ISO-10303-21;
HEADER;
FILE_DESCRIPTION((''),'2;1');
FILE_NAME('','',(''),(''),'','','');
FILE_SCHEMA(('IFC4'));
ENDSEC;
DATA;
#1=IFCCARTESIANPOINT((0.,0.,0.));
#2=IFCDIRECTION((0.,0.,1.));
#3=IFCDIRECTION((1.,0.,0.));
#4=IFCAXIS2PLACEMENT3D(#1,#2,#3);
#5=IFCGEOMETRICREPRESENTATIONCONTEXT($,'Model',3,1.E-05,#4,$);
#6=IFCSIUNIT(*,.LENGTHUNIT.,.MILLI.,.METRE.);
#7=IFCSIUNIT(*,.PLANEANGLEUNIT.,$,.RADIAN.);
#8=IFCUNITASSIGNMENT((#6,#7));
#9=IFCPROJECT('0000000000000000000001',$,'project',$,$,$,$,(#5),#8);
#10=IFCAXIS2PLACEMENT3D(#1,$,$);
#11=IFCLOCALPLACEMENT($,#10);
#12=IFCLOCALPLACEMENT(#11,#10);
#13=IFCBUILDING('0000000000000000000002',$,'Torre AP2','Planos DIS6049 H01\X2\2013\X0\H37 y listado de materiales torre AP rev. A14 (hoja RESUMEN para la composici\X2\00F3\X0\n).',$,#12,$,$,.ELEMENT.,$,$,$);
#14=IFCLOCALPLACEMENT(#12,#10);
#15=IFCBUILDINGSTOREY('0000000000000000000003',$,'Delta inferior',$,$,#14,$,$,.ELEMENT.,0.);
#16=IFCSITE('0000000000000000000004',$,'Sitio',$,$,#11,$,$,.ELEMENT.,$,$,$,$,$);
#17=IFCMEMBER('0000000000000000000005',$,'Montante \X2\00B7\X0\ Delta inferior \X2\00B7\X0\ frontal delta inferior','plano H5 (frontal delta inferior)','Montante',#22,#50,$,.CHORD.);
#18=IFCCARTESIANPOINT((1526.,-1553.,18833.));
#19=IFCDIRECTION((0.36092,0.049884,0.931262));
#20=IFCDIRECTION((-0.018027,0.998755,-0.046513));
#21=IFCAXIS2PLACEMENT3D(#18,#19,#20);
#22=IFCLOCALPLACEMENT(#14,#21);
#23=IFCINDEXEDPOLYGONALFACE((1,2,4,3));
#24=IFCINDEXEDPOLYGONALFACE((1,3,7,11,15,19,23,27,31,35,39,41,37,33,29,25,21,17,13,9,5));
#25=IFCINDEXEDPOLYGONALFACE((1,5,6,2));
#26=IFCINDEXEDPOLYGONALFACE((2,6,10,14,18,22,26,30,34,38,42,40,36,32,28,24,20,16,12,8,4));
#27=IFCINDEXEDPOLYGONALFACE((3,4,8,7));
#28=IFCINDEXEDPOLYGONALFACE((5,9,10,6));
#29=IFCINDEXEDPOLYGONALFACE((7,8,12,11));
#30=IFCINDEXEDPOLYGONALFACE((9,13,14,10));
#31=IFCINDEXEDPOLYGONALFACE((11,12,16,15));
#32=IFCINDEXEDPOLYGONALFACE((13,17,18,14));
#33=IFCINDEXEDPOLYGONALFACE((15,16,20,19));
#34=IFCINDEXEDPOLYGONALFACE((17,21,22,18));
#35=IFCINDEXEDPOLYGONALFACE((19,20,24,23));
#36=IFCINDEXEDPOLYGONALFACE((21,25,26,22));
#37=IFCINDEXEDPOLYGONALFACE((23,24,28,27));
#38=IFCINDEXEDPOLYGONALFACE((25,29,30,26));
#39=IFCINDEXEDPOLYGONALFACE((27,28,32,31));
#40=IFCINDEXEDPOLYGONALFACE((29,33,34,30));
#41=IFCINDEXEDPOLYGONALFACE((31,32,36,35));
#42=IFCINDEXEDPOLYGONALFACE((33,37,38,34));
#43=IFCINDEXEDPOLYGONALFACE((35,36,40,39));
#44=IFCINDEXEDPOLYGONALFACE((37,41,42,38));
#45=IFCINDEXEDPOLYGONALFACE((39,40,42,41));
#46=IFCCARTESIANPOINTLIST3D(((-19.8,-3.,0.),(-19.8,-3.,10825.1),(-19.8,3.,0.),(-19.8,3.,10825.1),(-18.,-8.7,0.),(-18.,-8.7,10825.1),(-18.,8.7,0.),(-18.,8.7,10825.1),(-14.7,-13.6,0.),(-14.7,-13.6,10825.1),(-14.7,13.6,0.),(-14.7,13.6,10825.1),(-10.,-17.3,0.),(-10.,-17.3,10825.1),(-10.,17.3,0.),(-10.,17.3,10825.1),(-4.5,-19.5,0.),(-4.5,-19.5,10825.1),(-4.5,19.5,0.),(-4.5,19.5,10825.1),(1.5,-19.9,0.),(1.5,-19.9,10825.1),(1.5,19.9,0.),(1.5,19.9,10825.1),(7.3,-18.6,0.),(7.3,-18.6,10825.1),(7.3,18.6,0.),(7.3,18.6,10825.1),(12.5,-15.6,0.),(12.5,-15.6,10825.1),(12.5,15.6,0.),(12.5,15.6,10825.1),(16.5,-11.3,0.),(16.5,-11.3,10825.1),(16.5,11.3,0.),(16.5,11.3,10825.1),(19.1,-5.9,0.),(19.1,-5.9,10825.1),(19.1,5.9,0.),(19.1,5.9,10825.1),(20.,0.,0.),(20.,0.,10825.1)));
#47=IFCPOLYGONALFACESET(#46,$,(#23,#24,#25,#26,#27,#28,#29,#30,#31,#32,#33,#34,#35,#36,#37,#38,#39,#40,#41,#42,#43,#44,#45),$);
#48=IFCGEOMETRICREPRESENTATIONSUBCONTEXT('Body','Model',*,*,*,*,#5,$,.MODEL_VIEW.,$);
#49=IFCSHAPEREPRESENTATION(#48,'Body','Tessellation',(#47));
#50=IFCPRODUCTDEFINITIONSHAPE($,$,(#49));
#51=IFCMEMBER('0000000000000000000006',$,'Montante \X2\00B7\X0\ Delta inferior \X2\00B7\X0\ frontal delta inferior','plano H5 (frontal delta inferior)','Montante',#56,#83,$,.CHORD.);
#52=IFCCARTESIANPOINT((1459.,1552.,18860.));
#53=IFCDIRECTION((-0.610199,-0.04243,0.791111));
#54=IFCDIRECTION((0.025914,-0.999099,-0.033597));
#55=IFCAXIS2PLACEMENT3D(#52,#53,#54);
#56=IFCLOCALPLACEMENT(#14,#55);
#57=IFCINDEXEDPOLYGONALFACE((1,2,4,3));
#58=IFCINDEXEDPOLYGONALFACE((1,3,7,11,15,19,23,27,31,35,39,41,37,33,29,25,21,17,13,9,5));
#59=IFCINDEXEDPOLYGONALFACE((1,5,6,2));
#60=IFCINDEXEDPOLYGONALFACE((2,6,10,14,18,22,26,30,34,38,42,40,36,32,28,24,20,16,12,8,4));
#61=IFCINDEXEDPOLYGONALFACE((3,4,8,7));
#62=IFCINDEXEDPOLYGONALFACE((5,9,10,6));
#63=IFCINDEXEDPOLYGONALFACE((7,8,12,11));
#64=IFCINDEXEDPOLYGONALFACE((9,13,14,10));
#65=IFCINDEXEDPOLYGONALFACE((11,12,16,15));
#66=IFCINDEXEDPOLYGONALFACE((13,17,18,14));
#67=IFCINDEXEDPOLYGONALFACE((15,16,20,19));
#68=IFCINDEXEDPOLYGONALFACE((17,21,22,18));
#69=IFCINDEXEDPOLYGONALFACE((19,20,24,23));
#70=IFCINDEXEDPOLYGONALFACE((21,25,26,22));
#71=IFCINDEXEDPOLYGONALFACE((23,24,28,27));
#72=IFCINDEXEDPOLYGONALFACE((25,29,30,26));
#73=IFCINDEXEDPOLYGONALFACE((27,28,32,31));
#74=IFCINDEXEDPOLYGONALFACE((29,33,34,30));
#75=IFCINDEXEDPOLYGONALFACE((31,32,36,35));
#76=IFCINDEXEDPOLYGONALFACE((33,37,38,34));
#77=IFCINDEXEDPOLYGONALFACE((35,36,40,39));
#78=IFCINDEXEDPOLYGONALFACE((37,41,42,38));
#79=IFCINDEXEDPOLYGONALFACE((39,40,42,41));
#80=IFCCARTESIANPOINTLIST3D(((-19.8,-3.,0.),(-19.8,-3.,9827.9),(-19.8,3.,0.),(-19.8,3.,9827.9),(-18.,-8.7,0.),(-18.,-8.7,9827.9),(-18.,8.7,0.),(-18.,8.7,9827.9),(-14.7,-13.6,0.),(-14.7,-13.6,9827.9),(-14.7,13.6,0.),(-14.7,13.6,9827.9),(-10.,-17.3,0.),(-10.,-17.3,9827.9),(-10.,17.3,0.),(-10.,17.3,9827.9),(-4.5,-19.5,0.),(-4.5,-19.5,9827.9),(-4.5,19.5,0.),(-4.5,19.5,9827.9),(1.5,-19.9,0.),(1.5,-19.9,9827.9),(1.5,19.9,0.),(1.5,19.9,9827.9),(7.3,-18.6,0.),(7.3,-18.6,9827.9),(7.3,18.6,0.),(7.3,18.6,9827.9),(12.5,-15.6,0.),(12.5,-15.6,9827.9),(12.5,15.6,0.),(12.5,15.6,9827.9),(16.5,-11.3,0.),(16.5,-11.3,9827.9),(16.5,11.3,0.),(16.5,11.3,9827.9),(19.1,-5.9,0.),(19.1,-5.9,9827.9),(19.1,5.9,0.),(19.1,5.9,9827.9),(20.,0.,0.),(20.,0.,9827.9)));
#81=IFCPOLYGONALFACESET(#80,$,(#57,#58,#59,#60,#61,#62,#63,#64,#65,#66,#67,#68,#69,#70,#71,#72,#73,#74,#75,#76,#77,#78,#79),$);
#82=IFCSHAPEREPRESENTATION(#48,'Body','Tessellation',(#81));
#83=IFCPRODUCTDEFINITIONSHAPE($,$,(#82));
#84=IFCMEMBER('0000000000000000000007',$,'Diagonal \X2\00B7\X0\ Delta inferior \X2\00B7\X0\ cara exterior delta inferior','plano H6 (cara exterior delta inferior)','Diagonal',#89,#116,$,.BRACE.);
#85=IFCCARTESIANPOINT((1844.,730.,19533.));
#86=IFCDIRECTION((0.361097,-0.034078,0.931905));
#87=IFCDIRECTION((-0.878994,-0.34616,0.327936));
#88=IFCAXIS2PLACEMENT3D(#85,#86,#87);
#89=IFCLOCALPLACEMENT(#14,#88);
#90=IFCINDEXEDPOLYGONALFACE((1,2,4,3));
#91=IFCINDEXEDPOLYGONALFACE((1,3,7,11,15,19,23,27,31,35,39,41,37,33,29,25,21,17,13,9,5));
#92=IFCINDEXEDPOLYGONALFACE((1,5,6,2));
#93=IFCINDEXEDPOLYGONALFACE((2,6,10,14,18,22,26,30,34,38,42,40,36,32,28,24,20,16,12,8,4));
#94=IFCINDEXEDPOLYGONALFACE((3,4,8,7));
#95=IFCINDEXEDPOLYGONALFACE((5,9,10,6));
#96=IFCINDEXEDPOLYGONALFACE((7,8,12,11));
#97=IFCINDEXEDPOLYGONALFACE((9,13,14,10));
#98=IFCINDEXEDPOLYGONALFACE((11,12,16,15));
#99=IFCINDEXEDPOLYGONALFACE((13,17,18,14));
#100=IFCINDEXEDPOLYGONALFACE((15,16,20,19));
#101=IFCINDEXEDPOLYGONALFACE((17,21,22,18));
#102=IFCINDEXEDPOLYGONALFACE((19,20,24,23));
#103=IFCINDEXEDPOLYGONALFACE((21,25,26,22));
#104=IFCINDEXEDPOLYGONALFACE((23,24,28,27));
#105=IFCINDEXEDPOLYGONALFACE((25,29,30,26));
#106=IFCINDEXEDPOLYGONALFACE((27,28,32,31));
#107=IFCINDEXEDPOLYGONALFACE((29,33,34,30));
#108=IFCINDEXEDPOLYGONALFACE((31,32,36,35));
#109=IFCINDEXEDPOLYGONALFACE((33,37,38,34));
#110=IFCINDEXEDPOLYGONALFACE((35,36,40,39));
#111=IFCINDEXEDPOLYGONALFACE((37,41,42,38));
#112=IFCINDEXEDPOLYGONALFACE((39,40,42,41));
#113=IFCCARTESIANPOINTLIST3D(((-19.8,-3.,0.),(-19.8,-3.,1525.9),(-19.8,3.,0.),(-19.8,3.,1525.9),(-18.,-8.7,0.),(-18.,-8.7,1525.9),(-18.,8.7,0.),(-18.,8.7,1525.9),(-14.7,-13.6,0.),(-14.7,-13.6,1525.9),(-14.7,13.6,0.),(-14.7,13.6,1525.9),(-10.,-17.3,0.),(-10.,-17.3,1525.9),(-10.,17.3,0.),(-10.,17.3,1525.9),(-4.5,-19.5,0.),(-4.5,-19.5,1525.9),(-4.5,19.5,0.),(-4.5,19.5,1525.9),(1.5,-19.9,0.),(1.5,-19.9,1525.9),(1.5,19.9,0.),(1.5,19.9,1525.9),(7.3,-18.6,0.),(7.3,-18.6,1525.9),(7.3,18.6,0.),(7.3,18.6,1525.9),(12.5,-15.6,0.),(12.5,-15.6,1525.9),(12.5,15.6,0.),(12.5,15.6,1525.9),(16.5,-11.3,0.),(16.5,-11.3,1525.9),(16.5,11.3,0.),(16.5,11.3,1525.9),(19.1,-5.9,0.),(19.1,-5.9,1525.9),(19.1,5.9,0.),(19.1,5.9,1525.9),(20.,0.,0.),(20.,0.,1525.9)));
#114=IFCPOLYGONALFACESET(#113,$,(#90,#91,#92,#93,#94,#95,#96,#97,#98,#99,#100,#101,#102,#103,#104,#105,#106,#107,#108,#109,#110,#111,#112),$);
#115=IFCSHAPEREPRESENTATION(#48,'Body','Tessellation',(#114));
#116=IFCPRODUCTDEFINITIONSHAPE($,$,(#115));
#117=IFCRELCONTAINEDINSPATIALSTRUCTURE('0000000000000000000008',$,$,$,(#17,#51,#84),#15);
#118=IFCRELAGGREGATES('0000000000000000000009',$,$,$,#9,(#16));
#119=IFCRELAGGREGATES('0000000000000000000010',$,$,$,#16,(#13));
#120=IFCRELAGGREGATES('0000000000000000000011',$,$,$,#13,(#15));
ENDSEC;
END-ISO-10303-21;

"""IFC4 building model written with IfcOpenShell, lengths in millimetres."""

from ifc_helpers import new_model, si_unit, frame, origin, origin_with_axes, place, context, subcontext, project, spatial, circle, extrude, element, save


model = new_model("IFC4")

# Units and contexts
model_context = context("Model", 3, precision=1e-05, world=origin_with_axes())
body_context = subcontext(model_context, "Body", "Model", "MODEL_VIEW")
ifc_project = project(units=[si_unit("LENGTHUNIT", "METRE", prefix="MILLI"), si_unit("PLANEANGLEUNIT", "RADIAN")], contexts=[model_context])

# Site, building, storey
site_placement = place(None, origin())
site = spatial("IfcSite", under=ifc_project, at=site_placement, Name="Sitio", CompositionType="ELEMENT")
building_placement = place(site_placement, origin())
building = spatial("IfcBuilding", under=site, at=building_placement, Name="Torre AP2", Description="Planos DIS6049 H01–H37 y listado de materiales torre AP rev. A14 (hoja RESUMEN para la composición).", CompositionType="ELEMENT")
storey_placement = place(building_placement, origin())
storey = spatial("IfcBuildingStorey", under=building, at=storey_placement, Name="Delta inferior", CompositionType="ELEMENT", Elevation=0.0)

# Members
for number, where, z_axis, x_axis, name in (
    (1, (1526.0, -1553.0, 18833.0), (0.36092, 0.049884, 0.931262), (-0.018027, 0.998755, -0.046513), "Montante · Delta inferior · frontal delta inferior"),
):
    element("IfcMember", number, at=place(storey_placement, frame(where, z_axis=z_axis, x_axis=x_axis)), inside=storey, Name=name, Description="plano H5 (frontal delta inferior)", ObjectType="Montante", PredefinedType="CHORD", context=body_context, shape_type="SweptSolid", body=[
        extrude(circle(Radius=20.0), None, (0.0, 0.0, 1.0), 10825.1),
    ])
for number, where, z_axis, x_axis, name in (
    (2, (1459.0, 1552.0, 18860.0), (-0.610199, -0.04243, 0.791111), (0.025914, -0.999099, -0.033597), "Montante · Delta inferior · frontal delta inferior"),
):
    element("IfcMember", number, at=place(storey_placement, frame(where, z_axis=z_axis, x_axis=x_axis)), inside=storey, Name=name, Description="plano H5 (frontal delta inferior)", ObjectType="Montante", PredefinedType="CHORD", context=body_context, shape_type="SweptSolid", body=[
        extrude(circle(Radius=20.0), None, (0.0, 0.0, 1.0), 9827.9),
    ])
member_1_placement = place(storey_placement, frame((1844.0, 730.0, 19533.0), z_axis=(0.361097, -0.034078, 0.931905), x_axis=(-0.878994, -0.34616, 0.327936)))
element("IfcMember", 3, at=member_1_placement, inside=storey, Name="Diagonal · Delta inferior · cara exterior delta inferior", Description="plano H6 (cara exterior delta inferior)", ObjectType="Diagonal", PredefinedType="BRACE", context=body_context, shape_type="SweptSolid", body=[
    extrude(circle(Radius=20.0), None, (0.0, 0.0, 1.0), 1525.9),
])

save(model, "model.ifc")
